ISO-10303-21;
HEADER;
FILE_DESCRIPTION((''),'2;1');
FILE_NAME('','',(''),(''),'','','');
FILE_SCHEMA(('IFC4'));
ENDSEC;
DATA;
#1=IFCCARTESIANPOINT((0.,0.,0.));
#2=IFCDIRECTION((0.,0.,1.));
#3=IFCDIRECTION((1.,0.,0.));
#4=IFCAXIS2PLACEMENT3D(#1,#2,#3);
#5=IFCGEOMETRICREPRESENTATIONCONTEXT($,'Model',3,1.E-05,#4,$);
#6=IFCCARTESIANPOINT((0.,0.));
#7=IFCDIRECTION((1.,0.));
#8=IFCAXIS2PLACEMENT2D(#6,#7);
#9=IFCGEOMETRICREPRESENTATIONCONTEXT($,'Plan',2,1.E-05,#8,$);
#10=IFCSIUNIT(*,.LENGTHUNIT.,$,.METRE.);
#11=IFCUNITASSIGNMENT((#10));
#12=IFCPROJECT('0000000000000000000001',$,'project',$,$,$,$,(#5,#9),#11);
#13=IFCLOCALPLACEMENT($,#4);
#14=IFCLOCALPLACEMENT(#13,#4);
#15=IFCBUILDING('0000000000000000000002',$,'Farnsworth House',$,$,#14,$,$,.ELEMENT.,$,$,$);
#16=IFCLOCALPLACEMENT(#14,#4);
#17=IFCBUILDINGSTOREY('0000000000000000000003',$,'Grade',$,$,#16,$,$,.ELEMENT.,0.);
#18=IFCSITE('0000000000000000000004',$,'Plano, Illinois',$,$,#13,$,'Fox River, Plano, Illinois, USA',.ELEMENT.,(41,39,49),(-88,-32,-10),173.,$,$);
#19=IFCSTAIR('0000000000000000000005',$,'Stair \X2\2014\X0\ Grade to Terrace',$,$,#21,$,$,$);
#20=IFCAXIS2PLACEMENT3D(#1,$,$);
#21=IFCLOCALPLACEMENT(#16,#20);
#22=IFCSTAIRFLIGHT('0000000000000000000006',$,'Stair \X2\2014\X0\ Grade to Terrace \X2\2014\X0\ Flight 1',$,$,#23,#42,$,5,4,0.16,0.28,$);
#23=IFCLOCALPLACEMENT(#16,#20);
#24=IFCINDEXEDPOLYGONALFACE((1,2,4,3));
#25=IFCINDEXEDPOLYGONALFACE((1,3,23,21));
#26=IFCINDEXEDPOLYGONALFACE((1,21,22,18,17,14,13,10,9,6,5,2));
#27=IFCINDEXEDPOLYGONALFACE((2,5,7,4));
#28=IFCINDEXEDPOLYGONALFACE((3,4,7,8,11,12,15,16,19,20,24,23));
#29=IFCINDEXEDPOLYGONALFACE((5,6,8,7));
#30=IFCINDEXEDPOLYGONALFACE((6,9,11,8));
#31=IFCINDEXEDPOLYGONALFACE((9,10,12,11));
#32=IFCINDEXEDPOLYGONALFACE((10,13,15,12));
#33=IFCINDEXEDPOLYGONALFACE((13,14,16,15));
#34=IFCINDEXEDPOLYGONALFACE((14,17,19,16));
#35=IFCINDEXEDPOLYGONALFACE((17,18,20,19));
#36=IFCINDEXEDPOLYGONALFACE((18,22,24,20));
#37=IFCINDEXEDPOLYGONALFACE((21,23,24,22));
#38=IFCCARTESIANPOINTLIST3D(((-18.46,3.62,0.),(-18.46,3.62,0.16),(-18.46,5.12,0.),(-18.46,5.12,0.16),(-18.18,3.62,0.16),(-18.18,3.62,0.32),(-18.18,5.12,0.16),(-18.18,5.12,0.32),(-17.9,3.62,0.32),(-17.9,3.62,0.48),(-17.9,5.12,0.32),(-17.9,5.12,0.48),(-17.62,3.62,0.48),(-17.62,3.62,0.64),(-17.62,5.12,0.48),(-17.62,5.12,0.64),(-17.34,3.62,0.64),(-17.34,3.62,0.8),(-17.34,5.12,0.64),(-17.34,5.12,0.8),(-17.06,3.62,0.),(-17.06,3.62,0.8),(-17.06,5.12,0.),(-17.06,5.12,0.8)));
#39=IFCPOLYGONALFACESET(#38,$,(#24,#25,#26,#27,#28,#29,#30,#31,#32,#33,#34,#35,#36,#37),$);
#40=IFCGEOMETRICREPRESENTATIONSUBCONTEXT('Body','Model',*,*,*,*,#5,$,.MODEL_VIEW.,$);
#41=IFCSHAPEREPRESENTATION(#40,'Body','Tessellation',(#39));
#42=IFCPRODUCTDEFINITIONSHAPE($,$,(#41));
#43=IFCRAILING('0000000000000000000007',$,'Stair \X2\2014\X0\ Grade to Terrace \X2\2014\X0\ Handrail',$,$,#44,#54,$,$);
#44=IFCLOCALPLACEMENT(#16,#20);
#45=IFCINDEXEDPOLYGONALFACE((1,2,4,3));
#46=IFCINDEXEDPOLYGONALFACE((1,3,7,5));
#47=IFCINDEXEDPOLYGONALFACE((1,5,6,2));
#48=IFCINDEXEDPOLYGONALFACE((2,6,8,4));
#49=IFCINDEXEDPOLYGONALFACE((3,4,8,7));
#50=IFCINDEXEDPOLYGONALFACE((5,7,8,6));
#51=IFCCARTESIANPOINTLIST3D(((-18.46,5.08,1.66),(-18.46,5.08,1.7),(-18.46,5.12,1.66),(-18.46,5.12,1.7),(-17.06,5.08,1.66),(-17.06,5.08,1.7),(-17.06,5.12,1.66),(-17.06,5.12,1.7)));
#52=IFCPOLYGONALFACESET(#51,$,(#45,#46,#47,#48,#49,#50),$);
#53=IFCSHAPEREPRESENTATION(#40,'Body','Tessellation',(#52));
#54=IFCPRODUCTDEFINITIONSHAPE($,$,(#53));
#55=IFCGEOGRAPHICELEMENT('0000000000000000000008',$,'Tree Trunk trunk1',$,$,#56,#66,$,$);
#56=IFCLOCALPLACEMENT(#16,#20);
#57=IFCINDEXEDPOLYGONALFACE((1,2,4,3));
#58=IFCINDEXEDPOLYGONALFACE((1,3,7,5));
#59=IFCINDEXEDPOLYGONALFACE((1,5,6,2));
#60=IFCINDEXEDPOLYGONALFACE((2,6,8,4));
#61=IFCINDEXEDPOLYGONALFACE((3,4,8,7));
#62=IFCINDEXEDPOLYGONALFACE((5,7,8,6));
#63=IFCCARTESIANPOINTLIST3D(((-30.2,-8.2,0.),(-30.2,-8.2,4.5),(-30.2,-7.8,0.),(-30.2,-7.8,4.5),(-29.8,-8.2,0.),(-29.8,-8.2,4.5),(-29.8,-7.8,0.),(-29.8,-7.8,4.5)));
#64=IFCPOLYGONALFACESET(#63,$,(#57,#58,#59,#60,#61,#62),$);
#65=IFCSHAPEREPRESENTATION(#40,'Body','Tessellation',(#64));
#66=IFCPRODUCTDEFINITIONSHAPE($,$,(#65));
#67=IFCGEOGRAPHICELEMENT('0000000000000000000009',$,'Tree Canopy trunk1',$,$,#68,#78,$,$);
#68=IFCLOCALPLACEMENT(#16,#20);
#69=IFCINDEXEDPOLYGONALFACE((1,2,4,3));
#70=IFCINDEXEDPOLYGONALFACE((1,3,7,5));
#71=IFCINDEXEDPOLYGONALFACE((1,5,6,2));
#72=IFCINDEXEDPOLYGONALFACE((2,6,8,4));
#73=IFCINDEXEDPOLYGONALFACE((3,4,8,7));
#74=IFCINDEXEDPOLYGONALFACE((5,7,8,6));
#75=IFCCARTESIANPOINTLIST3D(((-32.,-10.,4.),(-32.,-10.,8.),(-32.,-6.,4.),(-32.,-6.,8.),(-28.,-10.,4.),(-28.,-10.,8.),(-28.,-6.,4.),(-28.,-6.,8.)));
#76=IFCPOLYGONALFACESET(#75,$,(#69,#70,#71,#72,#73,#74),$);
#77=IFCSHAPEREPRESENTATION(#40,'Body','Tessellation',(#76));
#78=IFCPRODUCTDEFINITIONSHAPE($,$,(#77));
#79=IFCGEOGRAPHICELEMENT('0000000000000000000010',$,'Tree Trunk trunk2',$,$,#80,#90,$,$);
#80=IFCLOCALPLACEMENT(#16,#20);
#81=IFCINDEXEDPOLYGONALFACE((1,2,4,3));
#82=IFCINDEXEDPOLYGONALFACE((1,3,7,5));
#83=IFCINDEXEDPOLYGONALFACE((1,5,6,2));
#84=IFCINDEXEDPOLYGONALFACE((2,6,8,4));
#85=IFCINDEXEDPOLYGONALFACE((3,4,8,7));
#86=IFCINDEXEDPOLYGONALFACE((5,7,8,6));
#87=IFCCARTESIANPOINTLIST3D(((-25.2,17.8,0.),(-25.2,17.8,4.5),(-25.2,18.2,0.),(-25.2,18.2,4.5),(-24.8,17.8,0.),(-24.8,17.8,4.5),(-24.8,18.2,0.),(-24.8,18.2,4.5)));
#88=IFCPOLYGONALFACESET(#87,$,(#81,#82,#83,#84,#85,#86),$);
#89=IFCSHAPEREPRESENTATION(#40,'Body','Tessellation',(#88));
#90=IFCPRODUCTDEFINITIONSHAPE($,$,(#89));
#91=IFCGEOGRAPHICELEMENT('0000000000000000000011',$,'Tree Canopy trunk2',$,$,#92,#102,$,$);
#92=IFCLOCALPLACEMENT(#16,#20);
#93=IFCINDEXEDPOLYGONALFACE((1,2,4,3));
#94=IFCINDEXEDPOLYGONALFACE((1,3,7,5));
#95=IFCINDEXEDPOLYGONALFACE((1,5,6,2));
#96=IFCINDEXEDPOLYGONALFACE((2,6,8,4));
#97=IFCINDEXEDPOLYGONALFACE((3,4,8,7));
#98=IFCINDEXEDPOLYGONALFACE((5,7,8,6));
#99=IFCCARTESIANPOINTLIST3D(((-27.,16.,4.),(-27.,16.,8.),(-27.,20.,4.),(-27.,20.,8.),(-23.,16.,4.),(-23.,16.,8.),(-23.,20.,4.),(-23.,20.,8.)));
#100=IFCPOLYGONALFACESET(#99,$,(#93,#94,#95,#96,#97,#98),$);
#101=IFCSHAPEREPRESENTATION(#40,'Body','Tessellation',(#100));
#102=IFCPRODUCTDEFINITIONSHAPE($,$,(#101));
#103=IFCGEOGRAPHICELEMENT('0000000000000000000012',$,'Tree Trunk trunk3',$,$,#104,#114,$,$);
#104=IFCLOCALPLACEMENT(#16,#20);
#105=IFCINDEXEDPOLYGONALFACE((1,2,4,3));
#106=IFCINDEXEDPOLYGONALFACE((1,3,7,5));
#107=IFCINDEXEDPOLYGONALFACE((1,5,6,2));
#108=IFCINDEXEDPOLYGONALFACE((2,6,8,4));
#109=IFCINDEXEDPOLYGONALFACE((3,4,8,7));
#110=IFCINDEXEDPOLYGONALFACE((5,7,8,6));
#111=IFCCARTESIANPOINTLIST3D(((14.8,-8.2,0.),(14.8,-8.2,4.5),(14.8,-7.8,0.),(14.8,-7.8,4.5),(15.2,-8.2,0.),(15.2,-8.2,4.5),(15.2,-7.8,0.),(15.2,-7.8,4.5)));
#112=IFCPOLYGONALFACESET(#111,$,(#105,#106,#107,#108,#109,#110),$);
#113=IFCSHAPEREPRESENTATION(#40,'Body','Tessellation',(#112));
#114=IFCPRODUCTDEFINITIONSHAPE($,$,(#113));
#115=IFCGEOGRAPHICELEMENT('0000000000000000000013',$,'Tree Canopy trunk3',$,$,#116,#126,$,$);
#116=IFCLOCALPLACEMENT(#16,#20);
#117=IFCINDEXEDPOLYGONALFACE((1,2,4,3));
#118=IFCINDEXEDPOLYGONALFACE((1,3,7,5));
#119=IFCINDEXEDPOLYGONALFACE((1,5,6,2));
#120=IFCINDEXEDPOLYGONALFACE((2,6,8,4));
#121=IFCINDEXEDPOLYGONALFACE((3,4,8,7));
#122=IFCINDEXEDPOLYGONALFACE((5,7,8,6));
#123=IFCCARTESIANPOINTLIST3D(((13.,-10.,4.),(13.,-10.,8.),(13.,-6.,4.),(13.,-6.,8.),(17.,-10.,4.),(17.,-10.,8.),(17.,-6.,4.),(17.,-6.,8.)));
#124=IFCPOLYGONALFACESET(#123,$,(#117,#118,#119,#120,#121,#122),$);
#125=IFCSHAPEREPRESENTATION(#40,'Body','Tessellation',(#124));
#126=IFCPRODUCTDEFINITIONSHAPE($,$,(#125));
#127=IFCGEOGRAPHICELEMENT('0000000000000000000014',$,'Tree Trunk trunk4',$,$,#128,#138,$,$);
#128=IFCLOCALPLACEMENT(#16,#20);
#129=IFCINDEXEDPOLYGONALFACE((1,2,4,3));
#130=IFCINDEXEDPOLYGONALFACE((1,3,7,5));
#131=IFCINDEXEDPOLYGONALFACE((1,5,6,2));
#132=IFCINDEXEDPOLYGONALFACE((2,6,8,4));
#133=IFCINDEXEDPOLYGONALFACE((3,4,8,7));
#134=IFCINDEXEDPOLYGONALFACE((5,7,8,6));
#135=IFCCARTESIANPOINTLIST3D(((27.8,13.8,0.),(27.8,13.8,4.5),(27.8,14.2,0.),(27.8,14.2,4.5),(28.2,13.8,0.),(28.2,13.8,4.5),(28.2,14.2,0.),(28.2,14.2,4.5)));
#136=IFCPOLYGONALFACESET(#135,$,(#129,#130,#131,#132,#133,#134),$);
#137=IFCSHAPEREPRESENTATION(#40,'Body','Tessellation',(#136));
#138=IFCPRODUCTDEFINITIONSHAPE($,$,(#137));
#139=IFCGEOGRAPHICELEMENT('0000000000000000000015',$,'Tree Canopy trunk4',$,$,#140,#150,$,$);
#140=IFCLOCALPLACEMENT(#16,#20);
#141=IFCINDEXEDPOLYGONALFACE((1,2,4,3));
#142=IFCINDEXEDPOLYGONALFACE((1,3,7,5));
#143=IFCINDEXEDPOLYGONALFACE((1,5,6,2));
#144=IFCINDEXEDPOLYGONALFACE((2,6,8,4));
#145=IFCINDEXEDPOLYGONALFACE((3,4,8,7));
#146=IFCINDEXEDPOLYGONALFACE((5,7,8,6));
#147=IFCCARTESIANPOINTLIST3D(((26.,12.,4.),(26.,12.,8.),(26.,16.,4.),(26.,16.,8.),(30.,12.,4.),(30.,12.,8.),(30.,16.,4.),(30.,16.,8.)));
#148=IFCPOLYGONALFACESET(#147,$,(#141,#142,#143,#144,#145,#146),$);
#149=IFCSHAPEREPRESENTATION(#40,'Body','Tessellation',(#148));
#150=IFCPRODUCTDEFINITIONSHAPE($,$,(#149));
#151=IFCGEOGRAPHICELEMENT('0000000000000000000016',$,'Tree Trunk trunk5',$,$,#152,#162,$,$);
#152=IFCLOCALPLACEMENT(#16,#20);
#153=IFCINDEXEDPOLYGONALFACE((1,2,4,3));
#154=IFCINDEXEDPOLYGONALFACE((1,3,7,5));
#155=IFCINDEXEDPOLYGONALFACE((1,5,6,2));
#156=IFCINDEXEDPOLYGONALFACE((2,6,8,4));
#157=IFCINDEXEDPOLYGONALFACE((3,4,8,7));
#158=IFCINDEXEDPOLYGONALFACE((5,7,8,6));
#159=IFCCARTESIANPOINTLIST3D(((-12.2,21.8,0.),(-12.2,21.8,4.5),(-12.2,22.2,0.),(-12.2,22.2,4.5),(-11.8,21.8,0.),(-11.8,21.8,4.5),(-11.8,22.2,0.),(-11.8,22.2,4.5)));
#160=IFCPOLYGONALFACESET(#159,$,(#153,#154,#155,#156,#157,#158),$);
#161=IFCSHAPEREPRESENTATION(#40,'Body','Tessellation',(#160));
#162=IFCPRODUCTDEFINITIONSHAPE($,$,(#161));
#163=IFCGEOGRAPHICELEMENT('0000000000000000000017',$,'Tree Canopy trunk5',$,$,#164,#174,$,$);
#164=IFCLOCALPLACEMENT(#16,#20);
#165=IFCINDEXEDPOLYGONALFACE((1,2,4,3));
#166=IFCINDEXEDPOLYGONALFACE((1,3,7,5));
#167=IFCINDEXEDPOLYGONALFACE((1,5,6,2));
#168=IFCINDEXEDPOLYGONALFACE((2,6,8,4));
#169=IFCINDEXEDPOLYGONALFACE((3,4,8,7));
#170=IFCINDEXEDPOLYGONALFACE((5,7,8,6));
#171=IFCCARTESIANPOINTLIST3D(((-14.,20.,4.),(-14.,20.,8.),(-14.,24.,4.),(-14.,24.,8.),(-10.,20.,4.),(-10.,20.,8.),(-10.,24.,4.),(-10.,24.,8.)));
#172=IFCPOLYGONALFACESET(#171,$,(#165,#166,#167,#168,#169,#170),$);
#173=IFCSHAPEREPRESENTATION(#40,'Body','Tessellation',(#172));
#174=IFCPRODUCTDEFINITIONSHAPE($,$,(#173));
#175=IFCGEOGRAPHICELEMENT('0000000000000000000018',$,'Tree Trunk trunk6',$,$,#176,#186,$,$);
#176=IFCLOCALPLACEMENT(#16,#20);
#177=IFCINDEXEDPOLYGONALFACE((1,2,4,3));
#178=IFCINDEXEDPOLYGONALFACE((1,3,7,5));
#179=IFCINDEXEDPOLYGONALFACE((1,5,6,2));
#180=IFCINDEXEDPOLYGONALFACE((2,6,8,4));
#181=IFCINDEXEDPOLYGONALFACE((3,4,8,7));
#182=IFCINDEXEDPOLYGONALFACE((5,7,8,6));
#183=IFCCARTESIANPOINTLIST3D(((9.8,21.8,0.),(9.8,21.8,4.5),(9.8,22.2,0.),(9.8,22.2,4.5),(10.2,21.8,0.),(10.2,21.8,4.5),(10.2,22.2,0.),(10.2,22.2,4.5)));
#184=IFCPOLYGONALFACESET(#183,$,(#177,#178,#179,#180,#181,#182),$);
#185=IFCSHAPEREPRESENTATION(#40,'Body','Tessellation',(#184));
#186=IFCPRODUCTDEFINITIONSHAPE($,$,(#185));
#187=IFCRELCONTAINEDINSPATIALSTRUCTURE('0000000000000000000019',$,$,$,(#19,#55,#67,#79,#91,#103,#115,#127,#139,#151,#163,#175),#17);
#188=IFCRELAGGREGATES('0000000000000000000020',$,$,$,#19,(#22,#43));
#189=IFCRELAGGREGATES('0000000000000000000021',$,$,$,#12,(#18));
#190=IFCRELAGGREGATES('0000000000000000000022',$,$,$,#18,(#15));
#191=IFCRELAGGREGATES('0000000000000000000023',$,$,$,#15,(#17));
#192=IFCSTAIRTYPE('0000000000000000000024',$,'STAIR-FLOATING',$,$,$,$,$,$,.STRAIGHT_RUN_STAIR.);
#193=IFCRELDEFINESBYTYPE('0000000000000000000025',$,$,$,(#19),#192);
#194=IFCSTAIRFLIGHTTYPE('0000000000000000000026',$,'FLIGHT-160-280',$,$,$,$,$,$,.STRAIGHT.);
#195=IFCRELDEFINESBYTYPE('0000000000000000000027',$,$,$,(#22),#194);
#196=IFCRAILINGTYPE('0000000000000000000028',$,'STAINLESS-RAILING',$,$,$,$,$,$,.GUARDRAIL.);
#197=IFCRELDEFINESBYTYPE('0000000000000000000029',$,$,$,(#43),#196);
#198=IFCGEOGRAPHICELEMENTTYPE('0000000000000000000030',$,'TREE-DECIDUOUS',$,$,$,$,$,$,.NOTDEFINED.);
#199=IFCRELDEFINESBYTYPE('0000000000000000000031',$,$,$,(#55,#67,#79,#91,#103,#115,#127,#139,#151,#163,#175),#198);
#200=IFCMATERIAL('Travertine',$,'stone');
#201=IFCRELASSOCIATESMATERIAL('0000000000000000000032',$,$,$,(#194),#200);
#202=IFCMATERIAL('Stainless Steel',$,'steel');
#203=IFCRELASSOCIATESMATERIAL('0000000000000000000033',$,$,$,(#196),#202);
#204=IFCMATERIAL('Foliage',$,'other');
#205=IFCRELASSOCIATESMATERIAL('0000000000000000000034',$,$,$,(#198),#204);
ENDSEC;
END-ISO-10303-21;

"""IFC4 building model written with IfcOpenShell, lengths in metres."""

from ifc_helpers import new_model, si_unit, frame, origin_with_axes, origin_2d_with_axis, place, context, subcontext, project, spatial, polyline, rectangle, outline, extrude, material, type_object, element, aggregate, save


model = new_model("IFC4")

# Units and contexts
model_context = context("Model", 3, precision=1e-05, world=origin_with_axes())
plan_context = context("Plan", 2, precision=1e-05, world=origin_2d_with_axis())
body_context = subcontext(model_context, "Body", "Model", "MODEL_VIEW")
ifc_project = project(units=[si_unit("LENGTHUNIT", "METRE")], contexts=[model_context, plan_context])

# Site, building, storey
site_placement = place(None, origin_with_axes())
site = spatial("IfcSite", under=ifc_project, at=site_placement, Name="Plano, Illinois", LongName="Fox River, Plano, Illinois, USA", CompositionType="ELEMENT", RefLatitude=(41, 39, 49), RefLongitude=(-88, -32, -10), RefElevation=173.0)
building_placement = place(site_placement, origin_with_axes())
building = spatial("IfcBuilding", under=site, at=building_placement, Name="Farnsworth House", CompositionType="ELEMENT")
storey_placement = place(building_placement, origin_with_axes())
storey = spatial("IfcBuildingStorey", under=building, at=storey_placement, Name="Grade", CompositionType="ELEMENT", Elevation=0.0)

# Stair, stair flight, railing
stair_type = type_object("IfcStairType", Name="STAIR-FLOATING", PredefinedType="STRAIGHT_RUN_STAIR")
stair_placement = place(storey_placement, frame((-18.46, 3.62, 0.0), z_axis=(0.0, 0.0, 1.0), x_axis=(1.0, 0.0, 0.0)))
stair = element("IfcStair", 1, at=stair_placement, inside=storey, type_object=stair_type, Name="Stair — Grade to Terrace")
ifc_material_1 = material(Name="Travertine", Category="stone")
stair_flight_type = type_object("IfcStairFlightType", Name="FLIGHT-160-280", PredefinedType="STRAIGHT", material=ifc_material_1)
stair_flight_placement = place(stair_placement, origin_with_axes())
stair_flight = element("IfcStairFlight", 2, at=stair_flight_placement, type_object=stair_flight_type, Name="Stair — Grade to Terrace — Flight 1", NumberOfRisers=5, NumberOfTreads=4, RiserHeight=0.16, TreadLength=0.28, context=body_context, shape_type="SweptSolid", body=[
    extrude(outline(polyline([(0.0, 0.0), (0.0, 0.16), (0.28, 0.16), (0.28, 0.32), (0.56, 0.32), (0.56, 0.48), (0.84, 0.48), (0.84, 0.64), (1.12, 0.64), (1.12, 0.8), (1.4, 0.8), (1.4, 0.0), (0.0, 0.0)])), frame((0.0, 0.0, 0.0), z_axis=(0.0, -1.0, 0.0), x_axis=(1.0, 0.0, 0.0)), (0.0, 0.0, -1.0), 1.5),
])
ifc_material_2 = material(Name="Stainless Steel", Category="steel")
railing_type = type_object("IfcRailingType", Name="STAINLESS-RAILING", PredefinedType="GUARDRAIL", material=ifc_material_2)
railing_placement = place(stair_placement, frame((0.0, 1.46, 1.66), z_axis=(0.0, 0.0, 1.0), x_axis=(1.0, 0.0, 0.0)))
railing = element("IfcRailing", 3, at=railing_placement, type_object=railing_type, Name="Stair — Grade to Terrace — Handrail", context=body_context, shape_type="SweptSolid", body=[
    extrude(rectangle(XDim=1.4, YDim=0.04, at=origin_2d_with_axis()), frame((0.7, 0.02, 0.0), z_axis=(0.0, 0.0, 1.0), x_axis=(1.0, 0.0, 0.0)), (0.0, 0.0, 1.0), 0.04),
])
aggregate(stair, [stair_flight, railing])

# Geographic elements
ifc_material_3 = material(Name="Foliage", Category="other")
geographic_element_type_1 = type_object("IfcGeographicElementType", Name="TREE-DECIDUOUS", PredefinedType="NOTDEFINED", material=ifc_material_3)
geographic_element_1_placement = place(storey_placement, frame((-30.2, -8.2, 0.0), z_axis=(0.0, 0.0, 1.0), x_axis=(1.0, 0.0, 0.0)))
element("IfcGeographicElement", 4, at=geographic_element_1_placement, inside=storey, type_object=geographic_element_type_1, Name="Tree Trunk trunk1", context=body_context, shape_type="SweptSolid", body=[
    extrude(rectangle(XDim=0.4, YDim=0.4, at=origin_2d_with_axis()), frame((0.2, 0.2, 0.0), z_axis=(0.0, 0.0, 1.0), x_axis=(1.0, 0.0, 0.0)), (0.0, 0.0, 1.0), 4.5),
])
geographic_element_2_placement = place(storey_placement, frame((-32.0, -10.0, 4.0), z_axis=(0.0, 0.0, 1.0), x_axis=(1.0, 0.0, 0.0)))
element("IfcGeographicElement", 5, at=geographic_element_2_placement, inside=storey, type_object=geographic_element_type_1, Name="Tree Canopy trunk1", context=body_context, shape_type="SweptSolid", body=[
    extrude(rectangle(XDim=4.0, YDim=4.0, at=origin_2d_with_axis()), frame((2.0, 2.0, 0.0), z_axis=(0.0, 0.0, 1.0), x_axis=(1.0, 0.0, 0.0)), (0.0, 0.0, 1.0), 4.0),
])
geographic_element_3_placement = place(storey_placement, frame((-25.2, 17.8, 0.0), z_axis=(0.0, 0.0, 1.0), x_axis=(1.0, 0.0, 0.0)))
element("IfcGeographicElement", 6, at=geographic_element_3_placement, inside=storey, type_object=geographic_element_type_1, Name="Tree Trunk trunk2", context=body_context, shape_type="SweptSolid", body=[
    extrude(rectangle(XDim=0.4, YDim=0.4, at=origin_2d_with_axis()), frame((0.2, 0.2, 0.0), z_axis=(0.0, 0.0, 1.0), x_axis=(1.0, 0.0, 0.0)), (0.0, 0.0, 1.0), 4.5),
])
geographic_element_4_placement = place(storey_placement, frame((-27.0, 16.0, 4.0), z_axis=(0.0, 0.0, 1.0), x_axis=(1.0, 0.0, 0.0)))
element("IfcGeographicElement", 7, at=geographic_element_4_placement, inside=storey, type_object=geographic_element_type_1, Name="Tree Canopy trunk2", context=body_context, shape_type="SweptSolid", body=[
    extrude(rectangle(XDim=4.0, YDim=4.0, at=origin_2d_with_axis()), frame((2.0, 2.0, 0.0), z_axis=(0.0, 0.0, 1.0), x_axis=(1.0, 0.0, 0.0)), (0.0, 0.0, 1.0), 4.0),
])
geographic_element_5_placement = place(storey_placement, frame((14.8, -8.2, 0.0), z_axis=(0.0, 0.0, 1.0), x_axis=(1.0, 0.0, 0.0)))
element("IfcGeographicElement", 8, at=geographic_element_5_placement, inside=storey, type_object=geographic_element_type_1, Name="Tree Trunk trunk3", context=body_context, shape_type="SweptSolid", body=[
    extrude(rectangle(XDim=0.4, YDim=0.4, at=origin_2d_with_axis()), frame((0.2, 0.2, 0.0), z_axis=(0.0, 0.0, 1.0), x_axis=(1.0, 0.0, 0.0)), (0.0, 0.0, 1.0), 4.5),
])
geographic_element_6_placement = place(storey_placement, frame((13.0, -10.0, 4.0), z_axis=(0.0, 0.0, 1.0), x_axis=(1.0, 0.0, 0.0)))
element("IfcGeographicElement", 9, at=geographic_element_6_placement, inside=storey, type_object=geographic_element_type_1, Name="Tree Canopy trunk3", context=body_context, shape_type="SweptSolid", body=[
    extrude(rectangle(XDim=4.0, YDim=4.0, at=origin_2d_with_axis()), frame((2.0, 2.0, 0.0), z_axis=(0.0, 0.0, 1.0), x_axis=(1.0, 0.0, 0.0)), (0.0, 0.0, 1.0), 4.0),
])
geographic_element_7_placement = place(storey_placement, frame((27.8, 13.8, 0.0), z_axis=(0.0, 0.0, 1.0), x_axis=(1.0, 0.0, 0.0)))
element("IfcGeographicElement", 10, at=geographic_element_7_placement, inside=storey, type_object=geographic_element_type_1, Name="Tree Trunk trunk4", context=body_context, shape_type="SweptSolid", body=[
    extrude(rectangle(XDim=0.4, YDim=0.4, at=origin_2d_with_axis()), frame((0.2, 0.2, 0.0), z_axis=(0.0, 0.0, 1.0), x_axis=(1.0, 0.0, 0.0)), (0.0, 0.0, 1.0), 4.5),
])
geographic_element_8_placement = place(storey_placement, frame((26.0, 12.0, 4.0), z_axis=(0.0, 0.0, 1.0), x_axis=(1.0, 0.0, 0.0)))
element("IfcGeographicElement", 11, at=geographic_element_8_placement, inside=storey, type_object=geographic_element_type_1, Name="Tree Canopy trunk4", context=body_context, shape_type="SweptSolid", body=[
    extrude(rectangle(XDim=4.0, YDim=4.0, at=origin_2d_with_axis()), frame((2.0, 2.0, 0.0), z_axis=(0.0, 0.0, 1.0), x_axis=(1.0, 0.0, 0.0)), (0.0, 0.0, 1.0), 4.0),
])
geographic_element_9_placement = place(storey_placement, frame((-12.2, 21.8, 0.0), z_axis=(0.0, 0.0, 1.0), x_axis=(1.0, 0.0, 0.0)))
element("IfcGeographicElement", 12, at=geographic_element_9_placement, inside=storey, type_object=geographic_element_type_1, Name="Tree Trunk trunk5", context=body_context, shape_type="SweptSolid", body=[
    extrude(rectangle(XDim=0.4, YDim=0.4, at=origin_2d_with_axis()), frame((0.2, 0.2, 0.0), z_axis=(0.0, 0.0, 1.0), x_axis=(1.0, 0.0, 0.0)), (0.0, 0.0, 1.0), 4.5),
])
geographic_element_10_placement = place(storey_placement, frame((-14.0, 20.0, 4.0), z_axis=(0.0, 0.0, 1.0), x_axis=(1.0, 0.0, 0.0)))
element("IfcGeographicElement", 13, at=geographic_element_10_placement, inside=storey, type_object=geographic_element_type_1, Name="Tree Canopy trunk5", context=body_context, shape_type="SweptSolid", body=[
    extrude(rectangle(XDim=4.0, YDim=4.0, at=origin_2d_with_axis()), frame((2.0, 2.0, 0.0), z_axis=(0.0, 0.0, 1.0), x_axis=(1.0, 0.0, 0.0)), (0.0, 0.0, 1.0), 4.0),
])
geographic_element_11_placement = place(storey_placement, frame((9.8, 21.8, 0.0), z_axis=(0.0, 0.0, 1.0), x_axis=(1.0, 0.0, 0.0)))
element("IfcGeographicElement", 14, at=geographic_element_11_placement, inside=storey, type_object=geographic_element_type_1, Name="Tree Trunk trunk6", context=body_context, shape_type="SweptSolid", body=[
    extrude(rectangle(XDim=0.4, YDim=0.4, at=origin_2d_with_axis()), frame((0.2, 0.2, 0.0), z_axis=(0.0, 0.0, 1.0), x_axis=(1.0, 0.0, 0.0)), (0.0, 0.0, 1.0), 4.5),
])

save(model, "model.ifc")
